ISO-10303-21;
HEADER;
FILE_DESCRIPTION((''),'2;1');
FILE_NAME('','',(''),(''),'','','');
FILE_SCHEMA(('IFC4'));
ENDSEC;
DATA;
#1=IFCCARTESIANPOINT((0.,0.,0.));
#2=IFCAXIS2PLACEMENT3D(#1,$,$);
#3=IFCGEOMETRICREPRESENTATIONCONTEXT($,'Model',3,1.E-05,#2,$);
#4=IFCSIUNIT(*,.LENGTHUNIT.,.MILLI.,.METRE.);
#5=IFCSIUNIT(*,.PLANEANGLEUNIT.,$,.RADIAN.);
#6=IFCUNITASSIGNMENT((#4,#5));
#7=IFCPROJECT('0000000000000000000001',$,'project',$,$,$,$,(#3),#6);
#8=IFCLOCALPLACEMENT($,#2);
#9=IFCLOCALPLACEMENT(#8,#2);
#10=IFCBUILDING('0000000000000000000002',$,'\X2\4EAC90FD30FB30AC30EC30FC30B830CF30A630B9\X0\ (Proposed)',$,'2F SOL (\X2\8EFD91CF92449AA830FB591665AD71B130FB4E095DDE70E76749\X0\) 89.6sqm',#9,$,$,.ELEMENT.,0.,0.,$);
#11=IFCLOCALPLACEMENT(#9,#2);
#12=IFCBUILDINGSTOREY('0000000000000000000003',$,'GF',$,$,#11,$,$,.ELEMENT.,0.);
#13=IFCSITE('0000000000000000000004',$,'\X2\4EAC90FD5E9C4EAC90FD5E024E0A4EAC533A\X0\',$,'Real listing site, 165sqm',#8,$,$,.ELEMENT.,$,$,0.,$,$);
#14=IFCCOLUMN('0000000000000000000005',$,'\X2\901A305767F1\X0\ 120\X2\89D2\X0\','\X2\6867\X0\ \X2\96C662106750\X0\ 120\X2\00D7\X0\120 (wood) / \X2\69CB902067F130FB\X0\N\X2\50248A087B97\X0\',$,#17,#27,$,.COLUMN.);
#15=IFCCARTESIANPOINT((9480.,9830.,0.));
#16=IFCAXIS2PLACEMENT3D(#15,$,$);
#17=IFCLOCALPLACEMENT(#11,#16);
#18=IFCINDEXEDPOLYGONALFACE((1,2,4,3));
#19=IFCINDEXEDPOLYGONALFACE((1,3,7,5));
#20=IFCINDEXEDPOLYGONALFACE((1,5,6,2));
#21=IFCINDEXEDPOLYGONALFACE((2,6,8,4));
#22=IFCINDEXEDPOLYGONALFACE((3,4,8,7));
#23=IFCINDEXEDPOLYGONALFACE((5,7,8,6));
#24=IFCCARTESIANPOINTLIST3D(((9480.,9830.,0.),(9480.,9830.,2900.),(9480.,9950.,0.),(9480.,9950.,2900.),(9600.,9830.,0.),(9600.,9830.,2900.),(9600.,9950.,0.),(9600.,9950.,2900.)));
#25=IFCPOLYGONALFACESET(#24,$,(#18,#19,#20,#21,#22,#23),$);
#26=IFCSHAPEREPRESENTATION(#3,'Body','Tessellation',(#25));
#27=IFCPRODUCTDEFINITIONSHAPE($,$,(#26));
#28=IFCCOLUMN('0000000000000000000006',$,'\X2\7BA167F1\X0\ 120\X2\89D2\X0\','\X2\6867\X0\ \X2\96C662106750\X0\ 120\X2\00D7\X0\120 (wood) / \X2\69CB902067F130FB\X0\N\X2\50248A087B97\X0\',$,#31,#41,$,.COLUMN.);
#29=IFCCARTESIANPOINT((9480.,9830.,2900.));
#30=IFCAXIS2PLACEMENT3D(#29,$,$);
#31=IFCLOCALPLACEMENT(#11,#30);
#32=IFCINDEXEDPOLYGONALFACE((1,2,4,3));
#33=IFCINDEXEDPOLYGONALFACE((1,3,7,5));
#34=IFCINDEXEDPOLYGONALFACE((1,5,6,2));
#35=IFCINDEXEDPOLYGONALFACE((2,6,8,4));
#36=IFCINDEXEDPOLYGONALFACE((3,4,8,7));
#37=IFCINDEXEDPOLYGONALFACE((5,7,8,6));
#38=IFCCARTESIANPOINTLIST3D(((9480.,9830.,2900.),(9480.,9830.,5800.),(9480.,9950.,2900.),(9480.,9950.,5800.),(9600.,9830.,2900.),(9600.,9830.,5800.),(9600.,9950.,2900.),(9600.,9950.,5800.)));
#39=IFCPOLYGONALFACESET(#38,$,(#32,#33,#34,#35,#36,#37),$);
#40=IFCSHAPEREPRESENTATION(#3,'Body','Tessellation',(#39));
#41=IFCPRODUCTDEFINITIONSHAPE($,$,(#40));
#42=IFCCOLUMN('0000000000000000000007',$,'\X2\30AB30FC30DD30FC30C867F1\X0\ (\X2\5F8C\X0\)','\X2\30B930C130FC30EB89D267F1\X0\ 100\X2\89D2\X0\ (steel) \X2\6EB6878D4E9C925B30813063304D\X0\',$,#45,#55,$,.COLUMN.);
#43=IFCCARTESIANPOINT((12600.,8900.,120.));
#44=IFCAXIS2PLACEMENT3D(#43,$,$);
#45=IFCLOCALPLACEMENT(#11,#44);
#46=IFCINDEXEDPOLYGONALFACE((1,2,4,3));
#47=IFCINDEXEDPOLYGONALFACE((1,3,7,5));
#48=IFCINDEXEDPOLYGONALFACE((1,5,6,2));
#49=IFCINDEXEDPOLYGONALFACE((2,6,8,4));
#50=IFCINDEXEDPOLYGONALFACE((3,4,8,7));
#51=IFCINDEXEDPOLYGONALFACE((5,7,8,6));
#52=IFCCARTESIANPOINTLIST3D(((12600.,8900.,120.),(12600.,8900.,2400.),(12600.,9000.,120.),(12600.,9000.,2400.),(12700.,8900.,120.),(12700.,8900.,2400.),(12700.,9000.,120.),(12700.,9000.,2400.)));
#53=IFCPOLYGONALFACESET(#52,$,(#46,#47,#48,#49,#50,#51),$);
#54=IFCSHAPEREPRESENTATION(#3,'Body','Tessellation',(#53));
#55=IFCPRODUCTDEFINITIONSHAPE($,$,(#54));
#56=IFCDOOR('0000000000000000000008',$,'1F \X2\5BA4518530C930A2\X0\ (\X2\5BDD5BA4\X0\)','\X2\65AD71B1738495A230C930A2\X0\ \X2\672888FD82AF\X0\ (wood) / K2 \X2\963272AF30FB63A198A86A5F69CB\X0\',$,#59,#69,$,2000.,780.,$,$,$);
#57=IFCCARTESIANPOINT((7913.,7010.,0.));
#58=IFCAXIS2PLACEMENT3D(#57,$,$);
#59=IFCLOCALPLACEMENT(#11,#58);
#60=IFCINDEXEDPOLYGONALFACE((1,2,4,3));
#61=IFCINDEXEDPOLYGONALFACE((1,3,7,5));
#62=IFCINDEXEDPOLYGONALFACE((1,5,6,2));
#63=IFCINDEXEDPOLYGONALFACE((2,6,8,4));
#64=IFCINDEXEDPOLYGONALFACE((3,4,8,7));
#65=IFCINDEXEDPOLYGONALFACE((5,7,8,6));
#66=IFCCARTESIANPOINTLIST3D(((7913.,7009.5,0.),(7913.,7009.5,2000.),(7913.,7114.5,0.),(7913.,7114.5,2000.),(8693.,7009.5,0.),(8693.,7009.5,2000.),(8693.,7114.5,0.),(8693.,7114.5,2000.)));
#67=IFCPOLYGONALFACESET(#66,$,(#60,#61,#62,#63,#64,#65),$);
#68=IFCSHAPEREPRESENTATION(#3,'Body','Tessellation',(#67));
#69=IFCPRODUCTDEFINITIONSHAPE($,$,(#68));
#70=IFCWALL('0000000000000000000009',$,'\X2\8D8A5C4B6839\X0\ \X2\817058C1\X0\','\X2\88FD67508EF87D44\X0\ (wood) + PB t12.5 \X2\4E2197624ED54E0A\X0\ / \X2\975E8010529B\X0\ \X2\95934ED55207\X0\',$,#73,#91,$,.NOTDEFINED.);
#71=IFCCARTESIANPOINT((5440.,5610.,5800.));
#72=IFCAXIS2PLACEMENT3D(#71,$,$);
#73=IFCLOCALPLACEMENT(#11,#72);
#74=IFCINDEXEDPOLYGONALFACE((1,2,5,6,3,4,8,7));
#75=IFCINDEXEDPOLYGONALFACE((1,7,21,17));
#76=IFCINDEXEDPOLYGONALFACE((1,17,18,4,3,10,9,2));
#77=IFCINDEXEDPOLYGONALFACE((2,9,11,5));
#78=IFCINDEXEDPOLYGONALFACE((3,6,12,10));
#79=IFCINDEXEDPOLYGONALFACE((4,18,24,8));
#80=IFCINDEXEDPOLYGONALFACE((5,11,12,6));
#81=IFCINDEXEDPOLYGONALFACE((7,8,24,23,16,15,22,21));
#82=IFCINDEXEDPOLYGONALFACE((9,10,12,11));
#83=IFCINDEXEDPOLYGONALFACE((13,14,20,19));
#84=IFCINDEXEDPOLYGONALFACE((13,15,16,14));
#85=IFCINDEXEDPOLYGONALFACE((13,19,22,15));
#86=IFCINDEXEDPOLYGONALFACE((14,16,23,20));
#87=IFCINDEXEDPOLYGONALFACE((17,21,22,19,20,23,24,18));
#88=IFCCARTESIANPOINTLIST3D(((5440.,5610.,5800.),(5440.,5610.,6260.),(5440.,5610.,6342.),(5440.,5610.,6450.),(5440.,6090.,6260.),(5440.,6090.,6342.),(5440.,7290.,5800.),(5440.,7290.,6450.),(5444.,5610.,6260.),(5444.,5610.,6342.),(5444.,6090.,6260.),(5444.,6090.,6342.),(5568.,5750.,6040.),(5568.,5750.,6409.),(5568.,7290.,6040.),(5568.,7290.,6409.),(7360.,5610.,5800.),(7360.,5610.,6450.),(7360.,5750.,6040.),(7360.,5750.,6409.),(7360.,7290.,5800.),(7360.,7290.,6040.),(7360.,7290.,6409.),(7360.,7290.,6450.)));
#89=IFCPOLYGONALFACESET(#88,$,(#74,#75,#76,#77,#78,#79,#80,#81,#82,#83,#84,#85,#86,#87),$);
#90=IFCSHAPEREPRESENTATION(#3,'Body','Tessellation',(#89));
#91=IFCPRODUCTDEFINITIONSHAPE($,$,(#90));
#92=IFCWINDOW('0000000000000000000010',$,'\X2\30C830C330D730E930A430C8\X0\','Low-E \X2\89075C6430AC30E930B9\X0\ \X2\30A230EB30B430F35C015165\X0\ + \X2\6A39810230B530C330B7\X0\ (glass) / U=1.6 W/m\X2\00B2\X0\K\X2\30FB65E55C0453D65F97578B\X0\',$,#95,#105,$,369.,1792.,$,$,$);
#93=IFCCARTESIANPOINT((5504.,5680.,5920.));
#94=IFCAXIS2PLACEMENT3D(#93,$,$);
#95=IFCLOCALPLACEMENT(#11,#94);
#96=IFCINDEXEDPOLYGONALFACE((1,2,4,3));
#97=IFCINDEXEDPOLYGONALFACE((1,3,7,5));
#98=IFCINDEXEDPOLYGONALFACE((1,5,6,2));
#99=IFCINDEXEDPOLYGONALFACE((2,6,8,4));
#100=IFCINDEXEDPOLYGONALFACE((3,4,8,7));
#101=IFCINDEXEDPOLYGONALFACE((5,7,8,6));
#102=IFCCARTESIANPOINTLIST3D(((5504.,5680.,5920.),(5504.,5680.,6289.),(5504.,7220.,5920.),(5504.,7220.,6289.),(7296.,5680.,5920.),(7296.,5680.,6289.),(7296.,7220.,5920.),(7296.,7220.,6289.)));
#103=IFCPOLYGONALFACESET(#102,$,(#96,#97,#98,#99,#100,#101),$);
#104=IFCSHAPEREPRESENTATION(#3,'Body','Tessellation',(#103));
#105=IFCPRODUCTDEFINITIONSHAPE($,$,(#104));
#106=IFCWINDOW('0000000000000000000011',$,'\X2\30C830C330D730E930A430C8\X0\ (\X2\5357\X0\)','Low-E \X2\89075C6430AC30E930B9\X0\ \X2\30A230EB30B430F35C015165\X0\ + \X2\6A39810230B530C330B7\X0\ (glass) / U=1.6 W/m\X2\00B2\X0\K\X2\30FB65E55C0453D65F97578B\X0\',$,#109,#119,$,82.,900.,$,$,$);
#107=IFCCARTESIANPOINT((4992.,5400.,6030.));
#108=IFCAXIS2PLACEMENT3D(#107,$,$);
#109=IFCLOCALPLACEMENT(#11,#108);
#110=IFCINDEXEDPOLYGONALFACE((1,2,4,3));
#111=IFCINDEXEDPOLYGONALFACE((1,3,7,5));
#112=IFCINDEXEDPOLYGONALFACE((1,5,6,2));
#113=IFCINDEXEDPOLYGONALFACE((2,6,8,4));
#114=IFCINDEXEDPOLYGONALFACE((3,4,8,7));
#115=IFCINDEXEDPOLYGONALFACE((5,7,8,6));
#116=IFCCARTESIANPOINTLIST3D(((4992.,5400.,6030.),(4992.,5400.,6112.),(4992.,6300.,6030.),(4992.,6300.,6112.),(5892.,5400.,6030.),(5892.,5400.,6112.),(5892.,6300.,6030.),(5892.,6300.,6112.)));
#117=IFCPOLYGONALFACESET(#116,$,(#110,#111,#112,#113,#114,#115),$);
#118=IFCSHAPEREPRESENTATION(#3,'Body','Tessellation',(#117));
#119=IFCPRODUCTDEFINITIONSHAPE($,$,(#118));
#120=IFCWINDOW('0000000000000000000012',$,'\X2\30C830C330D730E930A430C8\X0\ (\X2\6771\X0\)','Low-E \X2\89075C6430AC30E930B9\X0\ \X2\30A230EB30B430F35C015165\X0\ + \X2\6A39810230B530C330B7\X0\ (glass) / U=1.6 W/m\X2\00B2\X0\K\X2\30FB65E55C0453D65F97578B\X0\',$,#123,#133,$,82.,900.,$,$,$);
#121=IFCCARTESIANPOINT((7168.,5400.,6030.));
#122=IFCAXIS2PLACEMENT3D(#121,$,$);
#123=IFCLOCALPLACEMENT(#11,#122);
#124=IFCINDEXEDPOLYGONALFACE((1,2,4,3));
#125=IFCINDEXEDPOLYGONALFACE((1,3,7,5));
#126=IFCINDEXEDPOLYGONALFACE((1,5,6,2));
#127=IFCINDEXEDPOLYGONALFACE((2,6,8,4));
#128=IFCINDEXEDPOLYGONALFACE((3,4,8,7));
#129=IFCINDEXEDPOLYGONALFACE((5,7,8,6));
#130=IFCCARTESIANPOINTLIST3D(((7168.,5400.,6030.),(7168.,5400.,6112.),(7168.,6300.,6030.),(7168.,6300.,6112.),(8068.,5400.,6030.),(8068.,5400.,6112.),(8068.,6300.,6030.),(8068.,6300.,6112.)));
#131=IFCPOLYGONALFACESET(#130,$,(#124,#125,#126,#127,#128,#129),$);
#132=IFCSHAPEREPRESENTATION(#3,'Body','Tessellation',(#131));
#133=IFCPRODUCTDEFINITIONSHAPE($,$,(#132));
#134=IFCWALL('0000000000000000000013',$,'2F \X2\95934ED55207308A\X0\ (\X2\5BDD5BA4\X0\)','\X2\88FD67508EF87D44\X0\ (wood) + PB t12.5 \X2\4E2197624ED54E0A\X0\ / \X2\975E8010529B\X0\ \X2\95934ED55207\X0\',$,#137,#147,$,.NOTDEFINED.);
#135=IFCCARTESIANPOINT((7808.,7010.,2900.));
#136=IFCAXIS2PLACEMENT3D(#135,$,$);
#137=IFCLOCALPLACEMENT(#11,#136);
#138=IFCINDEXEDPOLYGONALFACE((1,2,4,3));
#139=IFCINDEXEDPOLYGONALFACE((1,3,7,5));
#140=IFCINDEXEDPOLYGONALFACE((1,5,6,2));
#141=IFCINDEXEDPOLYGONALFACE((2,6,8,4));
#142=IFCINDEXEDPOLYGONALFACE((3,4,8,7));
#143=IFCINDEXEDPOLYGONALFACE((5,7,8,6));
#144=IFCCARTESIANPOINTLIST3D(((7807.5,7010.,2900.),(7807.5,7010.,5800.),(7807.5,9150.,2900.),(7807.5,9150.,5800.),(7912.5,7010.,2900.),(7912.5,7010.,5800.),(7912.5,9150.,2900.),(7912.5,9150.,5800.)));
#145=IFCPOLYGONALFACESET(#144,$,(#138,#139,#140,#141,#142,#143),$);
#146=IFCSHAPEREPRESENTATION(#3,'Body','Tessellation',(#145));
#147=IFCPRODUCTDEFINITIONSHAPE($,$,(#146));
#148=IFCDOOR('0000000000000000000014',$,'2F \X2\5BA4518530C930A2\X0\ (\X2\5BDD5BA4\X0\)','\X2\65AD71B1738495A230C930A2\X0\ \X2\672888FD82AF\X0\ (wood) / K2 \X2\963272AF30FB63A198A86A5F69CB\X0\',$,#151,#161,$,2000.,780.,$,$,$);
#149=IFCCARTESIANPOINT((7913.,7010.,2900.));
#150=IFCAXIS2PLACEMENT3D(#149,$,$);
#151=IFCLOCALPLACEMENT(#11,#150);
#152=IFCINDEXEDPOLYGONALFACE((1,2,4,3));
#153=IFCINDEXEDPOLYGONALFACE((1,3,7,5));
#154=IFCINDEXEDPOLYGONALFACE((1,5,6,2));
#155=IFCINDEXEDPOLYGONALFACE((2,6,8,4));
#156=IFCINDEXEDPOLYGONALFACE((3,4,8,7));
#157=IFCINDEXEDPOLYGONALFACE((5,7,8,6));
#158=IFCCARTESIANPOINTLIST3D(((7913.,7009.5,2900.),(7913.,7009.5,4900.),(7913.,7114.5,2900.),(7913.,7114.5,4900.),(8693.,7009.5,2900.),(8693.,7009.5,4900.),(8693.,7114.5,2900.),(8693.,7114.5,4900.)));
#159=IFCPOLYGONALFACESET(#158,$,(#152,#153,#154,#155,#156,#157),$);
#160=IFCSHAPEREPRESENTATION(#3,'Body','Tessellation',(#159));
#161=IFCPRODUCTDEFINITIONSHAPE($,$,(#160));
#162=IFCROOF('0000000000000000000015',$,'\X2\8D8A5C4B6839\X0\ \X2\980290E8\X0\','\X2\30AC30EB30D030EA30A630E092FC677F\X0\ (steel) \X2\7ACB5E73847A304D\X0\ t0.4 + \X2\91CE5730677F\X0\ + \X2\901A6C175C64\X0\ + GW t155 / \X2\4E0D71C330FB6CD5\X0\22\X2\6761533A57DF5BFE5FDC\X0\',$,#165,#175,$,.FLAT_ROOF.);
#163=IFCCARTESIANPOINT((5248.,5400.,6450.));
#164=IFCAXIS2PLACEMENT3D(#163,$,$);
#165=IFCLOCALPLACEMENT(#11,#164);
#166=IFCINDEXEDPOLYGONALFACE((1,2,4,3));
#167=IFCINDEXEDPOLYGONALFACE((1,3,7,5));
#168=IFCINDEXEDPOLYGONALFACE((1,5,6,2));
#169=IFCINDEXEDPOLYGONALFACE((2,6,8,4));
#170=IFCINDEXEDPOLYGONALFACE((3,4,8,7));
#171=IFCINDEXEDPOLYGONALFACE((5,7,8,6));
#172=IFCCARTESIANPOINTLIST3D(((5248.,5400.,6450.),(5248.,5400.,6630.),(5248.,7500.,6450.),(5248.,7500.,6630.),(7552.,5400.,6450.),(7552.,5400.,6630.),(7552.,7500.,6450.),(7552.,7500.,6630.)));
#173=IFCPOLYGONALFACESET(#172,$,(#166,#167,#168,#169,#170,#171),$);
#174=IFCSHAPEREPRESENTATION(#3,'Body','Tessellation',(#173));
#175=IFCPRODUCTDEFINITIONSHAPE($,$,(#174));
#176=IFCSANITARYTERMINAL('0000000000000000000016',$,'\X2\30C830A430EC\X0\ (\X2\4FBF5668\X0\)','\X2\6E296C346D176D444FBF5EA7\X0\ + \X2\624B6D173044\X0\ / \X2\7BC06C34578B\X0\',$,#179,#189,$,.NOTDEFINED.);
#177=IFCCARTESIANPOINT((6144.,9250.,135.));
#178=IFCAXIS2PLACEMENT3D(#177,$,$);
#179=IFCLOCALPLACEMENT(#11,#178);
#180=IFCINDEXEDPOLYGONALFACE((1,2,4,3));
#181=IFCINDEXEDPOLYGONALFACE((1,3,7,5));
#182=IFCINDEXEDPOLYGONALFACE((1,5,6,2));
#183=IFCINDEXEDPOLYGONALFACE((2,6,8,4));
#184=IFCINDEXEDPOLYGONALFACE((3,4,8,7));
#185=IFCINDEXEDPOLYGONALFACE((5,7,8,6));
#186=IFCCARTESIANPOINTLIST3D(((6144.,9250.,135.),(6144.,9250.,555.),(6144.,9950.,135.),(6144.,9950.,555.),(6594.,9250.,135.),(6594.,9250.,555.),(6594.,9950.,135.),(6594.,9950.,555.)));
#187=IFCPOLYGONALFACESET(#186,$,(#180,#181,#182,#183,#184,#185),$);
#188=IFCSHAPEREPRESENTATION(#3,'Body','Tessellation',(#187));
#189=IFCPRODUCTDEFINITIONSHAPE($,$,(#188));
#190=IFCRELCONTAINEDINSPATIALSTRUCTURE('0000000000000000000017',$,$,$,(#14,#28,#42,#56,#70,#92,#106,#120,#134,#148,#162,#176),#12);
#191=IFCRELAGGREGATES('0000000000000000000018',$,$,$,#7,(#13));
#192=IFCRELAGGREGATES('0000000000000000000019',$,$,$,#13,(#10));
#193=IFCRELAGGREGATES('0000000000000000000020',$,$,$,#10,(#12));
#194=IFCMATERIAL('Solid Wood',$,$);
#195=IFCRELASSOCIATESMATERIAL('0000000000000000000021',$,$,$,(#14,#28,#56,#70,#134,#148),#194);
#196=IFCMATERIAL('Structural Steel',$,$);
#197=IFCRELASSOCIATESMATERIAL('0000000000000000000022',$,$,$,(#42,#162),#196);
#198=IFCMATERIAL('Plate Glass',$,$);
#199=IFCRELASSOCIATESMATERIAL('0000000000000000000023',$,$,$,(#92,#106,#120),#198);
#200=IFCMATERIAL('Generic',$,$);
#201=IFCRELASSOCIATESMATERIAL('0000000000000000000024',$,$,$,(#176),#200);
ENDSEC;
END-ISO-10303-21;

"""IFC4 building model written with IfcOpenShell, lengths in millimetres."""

from ifc_helpers import new_model, si_unit, frame, frame_2d, origin, place, context, project, spatial, rectangle, extrude, material, element, fill, save


model = new_model("IFC4")

# Units and contexts
model_context = context("Model", 3, precision=1e-05, world=origin())
ifc_project = project(units=[si_unit("LENGTHUNIT", "METRE", prefix="MILLI"), si_unit("PLANEANGLEUNIT", "RADIAN")], contexts=[model_context])

# Site, building, storey
site_placement = place(None, origin())
site = spatial("IfcSite", under=ifc_project, at=site_placement, Name="京都府京都市上京区", ObjectType="Real listing site, 165sqm", CompositionType="ELEMENT", RefElevation=0.0)
building_placement = place(site_placement, origin())
building = spatial("IfcBuilding", under=site, at=building_placement, Name="京都・ガレージハウス (Proposed)", ObjectType="2F SOL (軽量鉄骨・外断熱・三州烧杉) 89.6sqm", CompositionType="ELEMENT", ElevationOfRefHeight=0.0, ElevationOfTerrain=0.0)
storey_placement = place(building_placement, origin())
storey = spatial("IfcBuildingStorey", under=building, at=storey_placement, Name="GF", CompositionType="ELEMENT", Elevation=0.0)

# Columns
ifc_material_1 = material(Name="Solid Wood")
column_1_placement = place(storey_placement, frame((9480.0, 9830.0, 0.0)))
element("IfcColumn", 1, at=column_1_placement, inside=storey, material=ifc_material_1, Name="通し柱 120角", Description="桧 集成材 120×120 (wood) / 構造柱・N値計算", PredefinedType="COLUMN", context=model_context, shape_type="SweptSolid", body=[
    extrude(rectangle(XDim=120.0, YDim=120.0, at=frame_2d((60.0, 60.0))), frame((9480.0, 9830.0, 0.0)), (0.0, 0.0, 1.0), 2900.0),
])
column_2_placement = place(storey_placement, frame((9480.0, 9830.0, 2900.0)))
element("IfcColumn", 2, at=column_2_placement, inside=storey, material=ifc_material_1, Name="管柱 120角", Description="桧 集成材 120×120 (wood) / 構造柱・N値計算", PredefinedType="COLUMN", context=model_context, shape_type="SweptSolid", body=[
    extrude(rectangle(XDim=120.0, YDim=120.0, at=frame_2d((60.0, 60.0))), frame((9480.0, 9830.0, 2900.0)), (0.0, 0.0, 1.0), 2900.0),
])
ifc_material_2 = material(Name="Structural Steel")
column_3_placement = place(storey_placement, frame((12600.0, 8900.0, 120.0)))
element("IfcColumn", 3, at=column_3_placement, inside=storey, material=ifc_material_2, Name="カーポート柱 (後)", Description="スチール角柱 100角 (steel) 溶融亜鉛めっき", PredefinedType="COLUMN", context=model_context, shape_type="SweptSolid", body=[
    extrude(rectangle(XDim=100.0, YDim=100.0, at=frame_2d((50.0, 50.0))), frame((12600.0, 8900.0, 120.0)), (0.0, 0.0, 1.0), 2280.0),
])

# Door
door_1_placement = place(storey_placement, frame((7913.0, 7010.0, 0.0)))
element("IfcDoor", 4, at=door_1_placement, inside=storey, material=ifc_material_1, Name="1F 室内ドア (寝室)", Description="断熱玄関ドア 木製芯 (wood) / K2 防犯・採風機構", OverallHeight=2000.0, OverallWidth=780.0, context=model_context, shape_type="SweptSolid", body=[
    extrude(rectangle(XDim=780.0, YDim=105.0, at=frame_2d((390.0, 52.0))), frame((7913.0, 7010.0, 0.0)), (0.0, 0.0, 1.0), 2000.0),
])

# Wall, openings, windows
wall_1_placement = place(storey_placement, frame((5440.0, 5610.0, 5800.0)))
wall_1 = element("IfcWall", 5, at=wall_1_placement, inside=storey, material=ifc_material_1, Name="越屋根 腰壁", Description="製材軸組 (wood) + PB t12.5 両面仕上 / 非耐力 間仕切", PredefinedType="NOTDEFINED", context=model_context, shape_type="SweptSolid", body=[
    extrude(rectangle(XDim=1920.0, YDim=1680.0, at=frame_2d((960.0, 840.0))), frame((5440.0, 5610.0, 5800.0)), (0.0, 0.0, 1.0), 650.0),
])
opening_1_placement = place(storey_placement, frame((5504.0, 5680.0, 5920.0)))
opening_1 = element("IfcOpeningElement", 6, at=opening_1_placement, cuts=wall_1, PredefinedType="NOTDEFINED", context=model_context, shape_type="SweptSolid", body=[
    extrude(rectangle(XDim=1792.0, YDim=1540.0, at=frame_2d((896.0, 770.0))), frame((5504.0, 5680.0, 5920.0)), (0.0, 0.0, 1.0), 369.0),
])
opening_2_placement = place(storey_placement, frame((4992.0, 5400.0, 6030.0)))
opening_2 = element("IfcOpeningElement", 7, at=opening_2_placement, cuts=wall_1, PredefinedType="NOTDEFINED", context=model_context, shape_type="SweptSolid", body=[
    extrude(rectangle(XDim=900.0, YDim=900.0, at=frame_2d((450.0, 450.0))), frame((4992.0, 5400.0, 6030.0)), (0.0, 0.0, 1.0), 82.0),
])
opening_3_placement = place(storey_placement, frame((7168.0, 5400.0, 6030.0)))
opening_3 = element("IfcOpeningElement", 8, at=opening_3_placement, cuts=wall_1, PredefinedType="NOTDEFINED", context=model_context, shape_type="SweptSolid", body=[
    extrude(rectangle(XDim=900.0, YDim=900.0, at=frame_2d((450.0, 450.0))), frame((7168.0, 5400.0, 6030.0)), (0.0, 0.0, 1.0), 82.0),
])
ifc_material_3 = material(Name="Plate Glass")
window_1_placement = place(storey_placement, frame((5504.0, 5680.0, 5920.0)))
window_1 = element("IfcWindow", 9, at=window_1_placement, inside=storey, material=ifc_material_3, Name="トップライト", Description="Low-E 複層ガラス アルゴン封入 + 樹脂サッシ (glass) / U=1.6 W/m²K・日射取得型", OverallHeight=369.0, OverallWidth=1792.0, context=model_context, shape_type="SweptSolid", body=[
    extrude(rectangle(XDim=1792.0, YDim=1540.0, at=frame_2d((896.0, 770.0))), frame((5504.0, 5680.0, 5920.0)), (0.0, 0.0, 1.0), 369.0),
])
fill(opening_1, window_1)
window_2_placement = place(storey_placement, frame((4992.0, 5400.0, 6030.0)))
window_2 = element("IfcWindow", 10, at=window_2_placement, inside=storey, material=ifc_material_3, Name="トップライト (南)", Description="Low-E 複層ガラス アルゴン封入 + 樹脂サッシ (glass) / U=1.6 W/m²K・日射取得型", OverallHeight=82.0, OverallWidth=900.0, context=model_context, shape_type="SweptSolid", body=[
    extrude(rectangle(XDim=900.0, YDim=900.0, at=frame_2d((450.0, 450.0))), frame((4992.0, 5400.0, 6030.0)), (0.0, 0.0, 1.0), 82.0),
])
fill(opening_2, window_2)
window_3_placement = place(storey_placement, frame((7168.0, 5400.0, 6030.0)))
window_3 = element("IfcWindow", 11, at=window_3_placement, inside=storey, material=ifc_material_3, Name="トップライト (東)", Description="Low-E 複層ガラス アルゴン封入 + 樹脂サッシ (glass) / U=1.6 W/m²K・日射取得型", OverallHeight=82.0, OverallWidth=900.0, context=model_context, shape_type="SweptSolid", body=[
    extrude(rectangle(XDim=900.0, YDim=900.0, at=frame_2d((450.0, 450.0))), frame((7168.0, 5400.0, 6030.0)), (0.0, 0.0, 1.0), 82.0),
])
fill(opening_3, window_3)

# Wall
wall_2_placement = place(storey_placement, frame((7808.0, 7010.0, 2900.0)))
element("IfcWall", 12, at=wall_2_placement, inside=storey, material=ifc_material_1, Name="2F 間仕切り (寝室)", Description="製材軸組 (wood) + PB t12.5 両面仕上 / 非耐力 間仕切", PredefinedType="NOTDEFINED", context=model_context, shape_type="SweptSolid", body=[
    extrude(rectangle(XDim=105.0, YDim=2140.0, at=frame_2d((52.0, 1070.0))), frame((7808.0, 7010.0, 2900.0)), (0.0, 0.0, 1.0), 2900.0),
])

# Door
door_2_placement = place(storey_placement, frame((7913.0, 7010.0, 2900.0)))
element("IfcDoor", 13, at=door_2_placement, inside=storey, material=ifc_material_1, Name="2F 室内ドア (寝室)", Description="断熱玄関ドア 木製芯 (wood) / K2 防犯・採風機構", OverallHeight=2000.0, OverallWidth=780.0, context=model_context, shape_type="SweptSolid", body=[
    extrude(rectangle(XDim=780.0, YDim=105.0, at=frame_2d((390.0, 52.0))), frame((7913.0, 7010.0, 2900.0)), (0.0, 0.0, 1.0), 2000.0),
])

# Roof
roof_placement = place(storey_placement, frame((5248.0, 5400.0, 6450.0)))
element("IfcRoof", 14, at=roof_placement, inside=storey, material=ifc_material_2, Name="越屋根 頂部", Description="ガルバリウム鋼板 (steel) 立平葺き t0.4 + 野地板 + 通気層 + GW t155 / 不燃・法22条区域対応", PredefinedType="FLAT_ROOF", context=model_context, shape_type="SweptSolid", body=[
    extrude(rectangle(XDim=2304.0, YDim=2100.0, at=frame_2d((1152.0, 1050.0))), frame((5248.0, 5400.0, 6450.0)), (0.0, 0.0, 1.0), 180.0),
])

# Sanitary terminal
ifc_material_4 = material(Name="Generic")
sanitary_terminal_placement = place(storey_placement, frame((6144.0, 9250.0, 135.0)))
element("IfcSanitaryTerminal", 15, at=sanitary_terminal_placement, inside=storey, material=ifc_material_4, Name="トイレ (便器)", Description="温水洗浄便座 + 手洗い / 節水型", PredefinedType="NOTDEFINED", context=model_context, shape_type="SweptSolid", body=[
    extrude(rectangle(XDim=450.0, YDim=700.0, at=frame_2d((225.0, 350.0))), frame((6144.0, 9250.0, 135.0)), (0.0, 0.0, 1.0), 420.0),
])

save(model, "model.ifc")
